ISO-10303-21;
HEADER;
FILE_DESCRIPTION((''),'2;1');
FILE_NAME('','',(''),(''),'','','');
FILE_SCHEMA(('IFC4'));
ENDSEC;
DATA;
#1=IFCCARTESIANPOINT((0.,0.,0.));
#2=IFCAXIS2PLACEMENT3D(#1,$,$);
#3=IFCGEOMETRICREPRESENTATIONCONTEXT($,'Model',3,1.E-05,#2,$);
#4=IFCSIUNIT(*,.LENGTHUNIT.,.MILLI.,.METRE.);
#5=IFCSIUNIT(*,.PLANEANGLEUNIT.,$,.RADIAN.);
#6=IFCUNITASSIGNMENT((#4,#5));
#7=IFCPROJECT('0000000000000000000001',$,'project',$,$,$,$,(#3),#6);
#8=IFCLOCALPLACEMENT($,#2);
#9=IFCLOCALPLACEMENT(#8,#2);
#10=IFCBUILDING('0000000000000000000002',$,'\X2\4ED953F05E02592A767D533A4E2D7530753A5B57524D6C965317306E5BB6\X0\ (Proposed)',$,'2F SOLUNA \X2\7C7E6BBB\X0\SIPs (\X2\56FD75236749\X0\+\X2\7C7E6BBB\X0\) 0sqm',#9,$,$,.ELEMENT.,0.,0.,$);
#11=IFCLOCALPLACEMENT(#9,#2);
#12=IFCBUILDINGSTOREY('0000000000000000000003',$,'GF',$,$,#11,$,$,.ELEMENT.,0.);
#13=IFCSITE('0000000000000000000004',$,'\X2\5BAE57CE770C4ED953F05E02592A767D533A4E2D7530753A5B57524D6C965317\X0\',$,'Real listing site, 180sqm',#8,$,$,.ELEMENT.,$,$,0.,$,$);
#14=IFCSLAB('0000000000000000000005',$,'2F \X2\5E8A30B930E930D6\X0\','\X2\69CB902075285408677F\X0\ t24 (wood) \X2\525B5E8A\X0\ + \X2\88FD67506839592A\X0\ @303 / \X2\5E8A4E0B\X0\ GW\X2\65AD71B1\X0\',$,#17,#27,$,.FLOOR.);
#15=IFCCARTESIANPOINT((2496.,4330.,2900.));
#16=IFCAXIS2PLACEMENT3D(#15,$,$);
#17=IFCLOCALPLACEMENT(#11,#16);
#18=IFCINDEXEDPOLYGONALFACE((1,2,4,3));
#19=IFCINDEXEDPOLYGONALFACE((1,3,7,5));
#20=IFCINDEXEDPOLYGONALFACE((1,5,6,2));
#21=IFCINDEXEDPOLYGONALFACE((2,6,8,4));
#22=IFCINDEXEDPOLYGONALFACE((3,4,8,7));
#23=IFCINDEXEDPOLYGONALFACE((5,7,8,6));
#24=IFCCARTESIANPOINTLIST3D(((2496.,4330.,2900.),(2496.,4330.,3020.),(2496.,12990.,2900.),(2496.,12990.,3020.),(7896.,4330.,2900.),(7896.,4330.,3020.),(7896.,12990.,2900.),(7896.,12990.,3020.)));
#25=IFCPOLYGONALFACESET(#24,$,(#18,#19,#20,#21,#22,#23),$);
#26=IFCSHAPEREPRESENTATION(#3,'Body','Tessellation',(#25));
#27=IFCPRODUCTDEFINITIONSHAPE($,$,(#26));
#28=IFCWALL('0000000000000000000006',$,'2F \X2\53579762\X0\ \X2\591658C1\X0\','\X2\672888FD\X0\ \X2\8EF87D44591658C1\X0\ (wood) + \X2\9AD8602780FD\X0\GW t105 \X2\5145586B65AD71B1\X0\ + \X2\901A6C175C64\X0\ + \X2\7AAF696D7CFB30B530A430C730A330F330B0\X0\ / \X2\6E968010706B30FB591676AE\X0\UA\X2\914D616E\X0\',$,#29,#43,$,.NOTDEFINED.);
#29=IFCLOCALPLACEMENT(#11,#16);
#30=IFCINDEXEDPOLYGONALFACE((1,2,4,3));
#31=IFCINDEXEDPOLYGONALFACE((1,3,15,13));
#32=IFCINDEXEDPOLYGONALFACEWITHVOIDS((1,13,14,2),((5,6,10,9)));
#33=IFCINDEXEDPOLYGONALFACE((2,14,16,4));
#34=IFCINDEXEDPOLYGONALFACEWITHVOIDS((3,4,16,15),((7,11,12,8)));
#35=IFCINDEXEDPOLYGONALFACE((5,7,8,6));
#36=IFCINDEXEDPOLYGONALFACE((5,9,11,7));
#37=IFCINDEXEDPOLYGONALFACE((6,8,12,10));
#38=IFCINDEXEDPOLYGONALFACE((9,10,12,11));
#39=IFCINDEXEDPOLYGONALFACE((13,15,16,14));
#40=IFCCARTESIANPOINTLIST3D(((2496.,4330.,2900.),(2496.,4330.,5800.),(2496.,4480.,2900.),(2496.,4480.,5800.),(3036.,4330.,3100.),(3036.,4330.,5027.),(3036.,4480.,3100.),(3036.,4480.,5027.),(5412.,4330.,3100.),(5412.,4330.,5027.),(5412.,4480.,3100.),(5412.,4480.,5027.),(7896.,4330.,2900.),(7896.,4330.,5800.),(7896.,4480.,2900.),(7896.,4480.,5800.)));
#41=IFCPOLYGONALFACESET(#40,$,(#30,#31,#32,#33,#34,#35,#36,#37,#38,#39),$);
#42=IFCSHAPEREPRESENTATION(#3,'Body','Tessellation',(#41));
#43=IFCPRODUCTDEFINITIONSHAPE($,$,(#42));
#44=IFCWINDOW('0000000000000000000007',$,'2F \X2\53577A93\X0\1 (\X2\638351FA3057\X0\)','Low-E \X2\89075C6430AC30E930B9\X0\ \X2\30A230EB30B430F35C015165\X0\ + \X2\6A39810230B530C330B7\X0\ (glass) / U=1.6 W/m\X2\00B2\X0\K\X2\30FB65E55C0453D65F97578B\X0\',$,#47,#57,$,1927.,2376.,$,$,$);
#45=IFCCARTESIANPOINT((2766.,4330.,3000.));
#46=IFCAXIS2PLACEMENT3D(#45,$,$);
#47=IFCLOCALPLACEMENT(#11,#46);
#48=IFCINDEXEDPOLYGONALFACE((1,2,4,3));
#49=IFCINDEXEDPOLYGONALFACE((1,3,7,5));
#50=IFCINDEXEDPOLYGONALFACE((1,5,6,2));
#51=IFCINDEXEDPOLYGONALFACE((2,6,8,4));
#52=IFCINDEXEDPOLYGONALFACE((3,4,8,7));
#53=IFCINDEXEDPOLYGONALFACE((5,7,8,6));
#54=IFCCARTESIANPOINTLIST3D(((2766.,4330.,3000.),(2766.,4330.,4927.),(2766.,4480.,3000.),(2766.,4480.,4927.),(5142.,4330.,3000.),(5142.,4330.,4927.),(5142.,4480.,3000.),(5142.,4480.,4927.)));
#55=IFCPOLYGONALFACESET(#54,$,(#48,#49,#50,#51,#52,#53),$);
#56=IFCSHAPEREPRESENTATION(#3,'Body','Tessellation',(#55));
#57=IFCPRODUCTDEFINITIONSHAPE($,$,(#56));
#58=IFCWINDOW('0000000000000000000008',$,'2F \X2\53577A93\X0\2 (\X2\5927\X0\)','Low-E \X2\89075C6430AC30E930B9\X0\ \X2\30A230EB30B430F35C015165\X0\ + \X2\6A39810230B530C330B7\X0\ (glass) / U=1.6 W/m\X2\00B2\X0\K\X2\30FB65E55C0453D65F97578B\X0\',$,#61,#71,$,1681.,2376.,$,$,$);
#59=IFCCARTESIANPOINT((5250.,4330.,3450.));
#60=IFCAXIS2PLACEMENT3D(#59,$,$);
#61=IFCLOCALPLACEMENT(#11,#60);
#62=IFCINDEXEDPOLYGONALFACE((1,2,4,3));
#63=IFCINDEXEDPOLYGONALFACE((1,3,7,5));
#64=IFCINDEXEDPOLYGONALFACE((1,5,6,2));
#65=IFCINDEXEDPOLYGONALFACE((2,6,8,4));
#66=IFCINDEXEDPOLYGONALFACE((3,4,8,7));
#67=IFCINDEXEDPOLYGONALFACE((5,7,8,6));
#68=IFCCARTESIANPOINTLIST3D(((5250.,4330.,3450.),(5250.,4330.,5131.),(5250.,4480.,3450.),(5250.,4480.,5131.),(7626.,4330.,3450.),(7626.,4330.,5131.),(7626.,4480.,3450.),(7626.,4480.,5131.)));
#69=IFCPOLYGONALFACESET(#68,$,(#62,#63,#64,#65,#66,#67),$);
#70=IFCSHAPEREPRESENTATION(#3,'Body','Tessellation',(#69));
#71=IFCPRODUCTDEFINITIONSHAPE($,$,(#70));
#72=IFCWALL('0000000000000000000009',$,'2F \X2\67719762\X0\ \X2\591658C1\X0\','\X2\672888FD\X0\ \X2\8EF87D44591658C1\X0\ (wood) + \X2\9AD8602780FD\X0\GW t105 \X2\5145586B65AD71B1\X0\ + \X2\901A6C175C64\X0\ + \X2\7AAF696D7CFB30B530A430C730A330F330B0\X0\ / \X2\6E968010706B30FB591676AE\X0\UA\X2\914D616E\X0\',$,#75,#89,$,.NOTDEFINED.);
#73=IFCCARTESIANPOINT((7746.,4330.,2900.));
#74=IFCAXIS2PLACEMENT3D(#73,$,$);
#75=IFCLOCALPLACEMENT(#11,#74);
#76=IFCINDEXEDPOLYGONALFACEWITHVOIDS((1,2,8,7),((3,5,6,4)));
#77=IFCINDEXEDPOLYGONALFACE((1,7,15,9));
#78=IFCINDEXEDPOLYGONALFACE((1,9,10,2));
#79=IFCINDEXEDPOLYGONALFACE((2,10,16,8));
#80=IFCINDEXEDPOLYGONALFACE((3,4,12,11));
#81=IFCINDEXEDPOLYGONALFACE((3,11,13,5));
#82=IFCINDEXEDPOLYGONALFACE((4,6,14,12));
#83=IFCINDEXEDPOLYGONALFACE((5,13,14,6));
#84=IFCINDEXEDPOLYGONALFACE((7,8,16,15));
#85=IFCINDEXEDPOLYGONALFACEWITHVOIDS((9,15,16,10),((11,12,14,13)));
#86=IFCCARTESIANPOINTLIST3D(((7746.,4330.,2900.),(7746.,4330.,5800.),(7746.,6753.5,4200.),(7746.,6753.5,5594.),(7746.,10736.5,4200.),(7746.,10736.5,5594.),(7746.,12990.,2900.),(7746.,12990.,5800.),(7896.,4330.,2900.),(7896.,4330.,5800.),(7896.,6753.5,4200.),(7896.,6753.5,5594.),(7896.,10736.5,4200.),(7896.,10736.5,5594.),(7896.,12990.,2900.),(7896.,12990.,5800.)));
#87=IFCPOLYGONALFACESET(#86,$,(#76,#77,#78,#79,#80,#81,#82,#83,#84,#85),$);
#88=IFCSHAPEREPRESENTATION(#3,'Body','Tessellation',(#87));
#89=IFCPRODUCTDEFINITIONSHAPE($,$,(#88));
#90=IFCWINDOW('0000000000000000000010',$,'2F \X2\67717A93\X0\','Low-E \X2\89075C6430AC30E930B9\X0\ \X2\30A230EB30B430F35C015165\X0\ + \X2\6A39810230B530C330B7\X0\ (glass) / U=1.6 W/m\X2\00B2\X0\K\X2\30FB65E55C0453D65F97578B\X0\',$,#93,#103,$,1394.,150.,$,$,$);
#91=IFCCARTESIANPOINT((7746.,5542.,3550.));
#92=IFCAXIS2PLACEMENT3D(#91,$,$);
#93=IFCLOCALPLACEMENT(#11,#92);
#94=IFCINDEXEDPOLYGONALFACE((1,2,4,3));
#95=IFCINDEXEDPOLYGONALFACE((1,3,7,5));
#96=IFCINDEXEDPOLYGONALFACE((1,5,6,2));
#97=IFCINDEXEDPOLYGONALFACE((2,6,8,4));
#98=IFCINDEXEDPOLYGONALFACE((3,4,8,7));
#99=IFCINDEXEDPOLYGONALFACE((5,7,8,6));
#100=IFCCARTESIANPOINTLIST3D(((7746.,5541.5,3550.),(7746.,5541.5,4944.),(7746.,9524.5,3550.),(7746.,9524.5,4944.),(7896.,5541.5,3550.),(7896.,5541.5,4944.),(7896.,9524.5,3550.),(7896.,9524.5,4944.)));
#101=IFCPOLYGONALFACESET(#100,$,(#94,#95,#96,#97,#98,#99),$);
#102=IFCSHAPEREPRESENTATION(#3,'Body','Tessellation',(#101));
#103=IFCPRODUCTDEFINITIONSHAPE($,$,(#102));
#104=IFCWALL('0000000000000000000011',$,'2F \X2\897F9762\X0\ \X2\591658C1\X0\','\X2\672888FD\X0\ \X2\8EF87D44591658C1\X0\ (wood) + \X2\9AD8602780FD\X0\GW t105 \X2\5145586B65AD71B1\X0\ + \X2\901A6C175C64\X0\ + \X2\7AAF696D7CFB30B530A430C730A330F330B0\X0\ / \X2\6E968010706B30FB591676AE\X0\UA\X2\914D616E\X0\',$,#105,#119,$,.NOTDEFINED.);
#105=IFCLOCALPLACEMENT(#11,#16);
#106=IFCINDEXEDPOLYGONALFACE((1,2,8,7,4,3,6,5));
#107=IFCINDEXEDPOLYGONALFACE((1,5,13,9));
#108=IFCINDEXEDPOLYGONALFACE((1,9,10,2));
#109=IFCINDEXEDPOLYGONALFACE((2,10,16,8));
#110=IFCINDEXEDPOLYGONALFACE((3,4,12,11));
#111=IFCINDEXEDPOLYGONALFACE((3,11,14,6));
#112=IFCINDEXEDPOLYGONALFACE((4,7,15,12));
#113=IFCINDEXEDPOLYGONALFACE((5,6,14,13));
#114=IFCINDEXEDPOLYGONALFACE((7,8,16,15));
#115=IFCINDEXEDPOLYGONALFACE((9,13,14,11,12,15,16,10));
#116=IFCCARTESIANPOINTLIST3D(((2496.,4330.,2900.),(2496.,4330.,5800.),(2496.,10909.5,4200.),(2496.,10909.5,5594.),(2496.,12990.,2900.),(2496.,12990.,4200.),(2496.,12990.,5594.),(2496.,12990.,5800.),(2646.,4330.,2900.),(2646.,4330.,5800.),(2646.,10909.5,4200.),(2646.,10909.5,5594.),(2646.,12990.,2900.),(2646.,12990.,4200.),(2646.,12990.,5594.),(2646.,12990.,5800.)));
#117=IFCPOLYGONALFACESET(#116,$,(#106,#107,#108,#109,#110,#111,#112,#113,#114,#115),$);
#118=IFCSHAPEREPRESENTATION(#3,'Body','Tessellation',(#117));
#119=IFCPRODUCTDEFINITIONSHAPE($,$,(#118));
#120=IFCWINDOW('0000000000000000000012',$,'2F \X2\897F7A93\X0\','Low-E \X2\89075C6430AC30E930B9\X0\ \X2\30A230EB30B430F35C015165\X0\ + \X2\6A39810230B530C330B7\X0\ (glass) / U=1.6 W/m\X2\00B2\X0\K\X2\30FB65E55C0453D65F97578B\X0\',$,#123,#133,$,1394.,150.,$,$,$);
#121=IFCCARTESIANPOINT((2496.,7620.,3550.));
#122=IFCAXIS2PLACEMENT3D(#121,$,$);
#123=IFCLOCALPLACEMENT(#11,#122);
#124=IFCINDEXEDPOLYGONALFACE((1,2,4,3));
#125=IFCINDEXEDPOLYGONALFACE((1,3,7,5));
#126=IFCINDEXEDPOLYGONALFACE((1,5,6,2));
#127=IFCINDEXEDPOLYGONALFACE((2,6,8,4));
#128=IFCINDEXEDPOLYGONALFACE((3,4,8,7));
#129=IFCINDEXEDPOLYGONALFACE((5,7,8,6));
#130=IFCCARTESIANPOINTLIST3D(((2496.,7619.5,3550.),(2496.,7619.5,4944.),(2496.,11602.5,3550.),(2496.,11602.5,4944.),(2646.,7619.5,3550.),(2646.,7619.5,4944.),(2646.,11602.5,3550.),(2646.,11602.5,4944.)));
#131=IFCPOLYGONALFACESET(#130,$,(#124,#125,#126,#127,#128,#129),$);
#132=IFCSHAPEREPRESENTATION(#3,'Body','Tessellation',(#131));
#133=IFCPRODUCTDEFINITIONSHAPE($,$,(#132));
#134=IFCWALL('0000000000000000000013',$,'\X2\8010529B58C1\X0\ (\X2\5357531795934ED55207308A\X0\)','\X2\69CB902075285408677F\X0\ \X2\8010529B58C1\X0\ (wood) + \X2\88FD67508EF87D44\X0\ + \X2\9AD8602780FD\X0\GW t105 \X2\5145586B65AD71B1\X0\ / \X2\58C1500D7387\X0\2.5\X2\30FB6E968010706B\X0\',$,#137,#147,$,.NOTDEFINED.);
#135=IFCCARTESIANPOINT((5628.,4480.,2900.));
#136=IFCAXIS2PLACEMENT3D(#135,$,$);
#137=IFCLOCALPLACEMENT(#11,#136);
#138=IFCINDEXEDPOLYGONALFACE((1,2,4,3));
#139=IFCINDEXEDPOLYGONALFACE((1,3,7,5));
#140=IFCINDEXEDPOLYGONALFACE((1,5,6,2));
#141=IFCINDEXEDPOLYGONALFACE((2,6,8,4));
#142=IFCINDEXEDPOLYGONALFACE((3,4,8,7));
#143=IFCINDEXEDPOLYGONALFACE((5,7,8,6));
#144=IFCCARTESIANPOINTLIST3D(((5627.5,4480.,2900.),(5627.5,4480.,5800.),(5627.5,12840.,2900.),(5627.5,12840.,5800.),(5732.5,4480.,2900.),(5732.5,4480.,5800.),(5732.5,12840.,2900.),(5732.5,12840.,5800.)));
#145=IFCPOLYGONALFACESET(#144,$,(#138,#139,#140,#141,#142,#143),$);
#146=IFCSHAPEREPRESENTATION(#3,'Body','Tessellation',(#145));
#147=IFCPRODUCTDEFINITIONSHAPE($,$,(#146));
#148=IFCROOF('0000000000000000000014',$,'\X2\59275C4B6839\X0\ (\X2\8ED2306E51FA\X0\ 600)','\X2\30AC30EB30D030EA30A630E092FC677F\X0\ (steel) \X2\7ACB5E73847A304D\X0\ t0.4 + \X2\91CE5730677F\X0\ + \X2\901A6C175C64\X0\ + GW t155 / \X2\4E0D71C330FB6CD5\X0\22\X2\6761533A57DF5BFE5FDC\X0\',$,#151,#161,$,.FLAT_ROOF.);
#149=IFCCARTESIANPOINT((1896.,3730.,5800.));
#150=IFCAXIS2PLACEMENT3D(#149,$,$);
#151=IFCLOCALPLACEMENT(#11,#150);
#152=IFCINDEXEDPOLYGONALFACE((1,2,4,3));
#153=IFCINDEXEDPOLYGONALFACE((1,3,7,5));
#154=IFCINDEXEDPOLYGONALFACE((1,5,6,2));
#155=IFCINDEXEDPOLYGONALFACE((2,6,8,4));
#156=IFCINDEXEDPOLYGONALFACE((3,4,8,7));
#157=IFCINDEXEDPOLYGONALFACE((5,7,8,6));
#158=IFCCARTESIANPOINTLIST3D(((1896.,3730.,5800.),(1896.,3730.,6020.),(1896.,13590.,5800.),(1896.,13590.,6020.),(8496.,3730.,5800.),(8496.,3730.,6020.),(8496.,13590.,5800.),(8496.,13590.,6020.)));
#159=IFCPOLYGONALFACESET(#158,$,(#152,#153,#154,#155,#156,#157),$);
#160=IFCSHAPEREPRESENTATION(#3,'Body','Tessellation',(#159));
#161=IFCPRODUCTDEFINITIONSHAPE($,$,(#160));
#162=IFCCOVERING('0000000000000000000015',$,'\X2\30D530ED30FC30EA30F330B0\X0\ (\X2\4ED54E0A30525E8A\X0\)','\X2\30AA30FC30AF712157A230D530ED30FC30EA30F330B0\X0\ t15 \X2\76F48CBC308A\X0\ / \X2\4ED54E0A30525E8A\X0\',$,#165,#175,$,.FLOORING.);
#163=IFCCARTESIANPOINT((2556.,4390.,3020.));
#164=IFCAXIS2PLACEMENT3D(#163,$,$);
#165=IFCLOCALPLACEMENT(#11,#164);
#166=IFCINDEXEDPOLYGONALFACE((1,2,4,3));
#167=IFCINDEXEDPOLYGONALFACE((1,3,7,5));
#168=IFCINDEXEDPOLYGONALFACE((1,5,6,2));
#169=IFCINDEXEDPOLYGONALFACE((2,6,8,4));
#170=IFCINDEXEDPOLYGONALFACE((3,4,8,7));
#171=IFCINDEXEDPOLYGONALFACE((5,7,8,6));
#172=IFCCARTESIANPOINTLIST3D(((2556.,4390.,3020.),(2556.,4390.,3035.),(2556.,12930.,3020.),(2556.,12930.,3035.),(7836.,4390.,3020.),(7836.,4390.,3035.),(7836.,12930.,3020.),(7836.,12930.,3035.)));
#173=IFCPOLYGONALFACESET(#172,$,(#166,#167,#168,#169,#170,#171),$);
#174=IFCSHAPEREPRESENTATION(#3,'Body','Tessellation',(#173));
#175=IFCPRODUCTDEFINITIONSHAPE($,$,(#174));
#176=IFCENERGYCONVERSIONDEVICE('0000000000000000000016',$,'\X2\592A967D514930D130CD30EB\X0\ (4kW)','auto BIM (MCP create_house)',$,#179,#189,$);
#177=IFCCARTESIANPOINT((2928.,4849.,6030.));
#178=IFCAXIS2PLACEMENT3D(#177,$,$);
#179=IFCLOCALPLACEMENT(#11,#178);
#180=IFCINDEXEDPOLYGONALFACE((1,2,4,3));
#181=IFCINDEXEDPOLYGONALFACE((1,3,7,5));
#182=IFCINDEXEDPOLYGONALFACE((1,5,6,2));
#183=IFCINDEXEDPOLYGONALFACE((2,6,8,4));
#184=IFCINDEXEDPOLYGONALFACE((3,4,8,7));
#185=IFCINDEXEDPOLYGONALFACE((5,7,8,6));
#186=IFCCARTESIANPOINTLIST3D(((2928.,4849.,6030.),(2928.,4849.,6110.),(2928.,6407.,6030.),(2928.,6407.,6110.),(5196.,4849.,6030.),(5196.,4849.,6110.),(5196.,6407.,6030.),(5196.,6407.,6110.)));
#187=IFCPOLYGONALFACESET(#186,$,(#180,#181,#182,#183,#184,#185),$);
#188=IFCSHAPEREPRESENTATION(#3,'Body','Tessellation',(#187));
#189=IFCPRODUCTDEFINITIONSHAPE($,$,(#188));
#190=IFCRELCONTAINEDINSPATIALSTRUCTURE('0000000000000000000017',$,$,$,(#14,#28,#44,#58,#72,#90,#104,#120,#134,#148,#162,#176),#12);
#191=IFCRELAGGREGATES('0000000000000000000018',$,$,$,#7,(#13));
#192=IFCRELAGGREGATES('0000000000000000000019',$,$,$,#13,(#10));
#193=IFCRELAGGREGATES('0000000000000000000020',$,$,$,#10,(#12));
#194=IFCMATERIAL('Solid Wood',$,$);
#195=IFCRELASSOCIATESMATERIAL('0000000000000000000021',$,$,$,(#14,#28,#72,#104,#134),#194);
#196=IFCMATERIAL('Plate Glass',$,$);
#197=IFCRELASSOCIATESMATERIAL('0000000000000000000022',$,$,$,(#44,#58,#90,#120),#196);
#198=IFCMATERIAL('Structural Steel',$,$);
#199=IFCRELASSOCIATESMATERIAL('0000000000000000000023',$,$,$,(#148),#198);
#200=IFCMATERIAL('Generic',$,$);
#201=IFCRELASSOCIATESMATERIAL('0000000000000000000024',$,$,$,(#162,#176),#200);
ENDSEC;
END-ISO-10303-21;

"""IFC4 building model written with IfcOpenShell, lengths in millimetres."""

from ifc_helpers import new_model, si_unit, frame, frame_2d, origin, place, context, project, spatial, rectangle, extrude, material, element, fill, save


model = new_model("IFC4")

# Units and contexts
model_context = context("Model", 3, precision=1e-05, world=origin())
ifc_project = project(units=[si_unit("LENGTHUNIT", "METRE", prefix="MILLI"), si_unit("PLANEANGLEUNIT", "RADIAN")], contexts=[model_context])

# Site, building, storey
site_placement = place(None, origin())
site = spatial("IfcSite", under=ifc_project, at=site_placement, Name="宮城県仙台市太白区中田町字前沖北", ObjectType="Real listing site, 180sqm", CompositionType="ELEMENT", RefElevation=0.0)
building_placement = place(site_placement, origin())
building = spatial("IfcBuilding", under=site, at=building_placement, Name="仙台市太白区中田町字前沖北の家 (Proposed)", ObjectType="2F SOLUNA 籾殻SIPs (国産杉+籾殻) 0sqm", CompositionType="ELEMENT", ElevationOfRefHeight=0.0, ElevationOfTerrain=0.0)
storey_placement = place(building_placement, origin())
storey = spatial("IfcBuildingStorey", under=building, at=storey_placement, Name="GF", CompositionType="ELEMENT", Elevation=0.0)

# Slab
ifc_material_1 = material(Name="Solid Wood")
slab_placement = place(storey_placement, frame((2496.0, 4330.0, 2900.0)))
element("IfcSlab", 1, at=slab_placement, inside=storey, material=ifc_material_1, Name="2F 床スラブ", Description="構造用合板 t24 (wood) 剛床 + 製材根太 @303 / 床下 GW断熱", PredefinedType="FLOOR", context=model_context, shape_type="SweptSolid", body=[
    extrude(rectangle(XDim=5400.0, YDim=8660.0, at=frame_2d((2700.0, 4330.0))), frame((2496.0, 4330.0, 2900.0)), (0.0, 0.0, 1.0), 120.0),
])

# Wall, openings, windows
wall_1_placement = place(storey_placement, frame((2496.0, 4330.0, 2900.0)))
wall_1 = element("IfcWall", 2, at=wall_1_placement, inside=storey, material=ifc_material_1, Name="2F 南面 外壁", Description="木製 軸組外壁 (wood) + 高性能GW t105 充填断熱 + 通気層 + 窯業系サイディング / 準耐火・外皮UA配慮", PredefinedType="NOTDEFINED", context=model_context, shape_type="SweptSolid", body=[
    extrude(rectangle(XDim=5400.0, YDim=150.0, at=frame_2d((2700.0, 75.0))), frame((2496.0, 4330.0, 2900.0)), (0.0, 0.0, 1.0), 2900.0),
])
opening_1_placement = place(storey_placement, frame((2766.0, 4330.0, 3000.0)))
opening_1 = element("IfcOpeningElement", 3, at=opening_1_placement, cuts=wall_1, PredefinedType="NOTDEFINED", context=model_context, shape_type="SweptSolid", body=[
    extrude(rectangle(XDim=2376.0, YDim=150.0, at=frame_2d((1188.0, 75.0))), frame((2766.0, 4330.0, 3000.0)), (0.0, 0.0, 1.0), 1927.0),
])
opening_2_placement = place(storey_placement, frame((5250.0, 4330.0, 3450.0)))
opening_2 = element("IfcOpeningElement", 4, at=opening_2_placement, cuts=wall_1, PredefinedType="NOTDEFINED", context=model_context, shape_type="SweptSolid", body=[
    extrude(rectangle(XDim=2376.0, YDim=150.0, at=frame_2d((1188.0, 75.0))), frame((5250.0, 4330.0, 3450.0)), (0.0, 0.0, 1.0), 1681.0),
])
ifc_material_2 = material(Name="Plate Glass")
window_1_placement = place(storey_placement, frame((2766.0, 4330.0, 3000.0)))
window_1 = element("IfcWindow", 5, at=window_1_placement, inside=storey, material=ifc_material_2, Name="2F 南窓1 (掃出し)", Description="Low-E 複層ガラス アルゴン封入 + 樹脂サッシ (glass) / U=1.6 W/m²K・日射取得型", OverallHeight=1927.0, OverallWidth=2376.0, context=model_context, shape_type="SweptSolid", body=[
    extrude(rectangle(XDim=2376.0, YDim=150.0, at=frame_2d((1188.0, 75.0))), frame((2766.0, 4330.0, 3000.0)), (0.0, 0.0, 1.0), 1927.0),
])
fill(opening_1, window_1)
window_2_placement = place(storey_placement, frame((5250.0, 4330.0, 3450.0)))
window_2 = element("IfcWindow", 6, at=window_2_placement, inside=storey, material=ifc_material_2, Name="2F 南窓2 (大)", Description="Low-E 複層ガラス アルゴン封入 + 樹脂サッシ (glass) / U=1.6 W/m²K・日射取得型", OverallHeight=1681.0, OverallWidth=2376.0, context=model_context, shape_type="SweptSolid", body=[
    extrude(rectangle(XDim=2376.0, YDim=150.0, at=frame_2d((1188.0, 75.0))), frame((5250.0, 4330.0, 3450.0)), (0.0, 0.0, 1.0), 1681.0),
])
fill(opening_2, window_2)

# Walls, openings, windows
wall_2_placement = place(storey_placement, frame((7746.0, 4330.0, 2900.0)))
wall_2 = element("IfcWall", 7, at=wall_2_placement, inside=storey, material=ifc_material_1, Name="2F 東面 外壁", Description="木製 軸組外壁 (wood) + 高性能GW t105 充填断熱 + 通気層 + 窯業系サイディング / 準耐火・外皮UA配慮", PredefinedType="NOTDEFINED", context=model_context, shape_type="SweptSolid", body=[
    extrude(rectangle(XDim=150.0, YDim=8660.0, at=frame_2d((75.0, 4330.0))), frame((7746.0, 4330.0, 2900.0)), (0.0, 0.0, 1.0), 2900.0),
])
opening_3_placement = place(storey_placement, frame((7746.0, 5542.0, 3550.0)))
opening_3 = element("IfcOpeningElement", 8, at=opening_3_placement, cuts=wall_2, PredefinedType="NOTDEFINED", context=model_context, shape_type="SweptSolid", body=[
    extrude(rectangle(XDim=150.0, YDim=3983.0, at=frame_2d((75.0, 1991.0))), frame((7746.0, 5542.0, 3550.0)), (0.0, 0.0, 1.0), 1394.0),
])
window_3_placement = place(storey_placement, frame((7746.0, 5542.0, 3550.0)))
window_3 = element("IfcWindow", 9, at=window_3_placement, inside=storey, material=ifc_material_2, Name="2F 東窓", Description="Low-E 複層ガラス アルゴン封入 + 樹脂サッシ (glass) / U=1.6 W/m²K・日射取得型", OverallHeight=1394.0, OverallWidth=150.0, context=model_context, shape_type="SweptSolid", body=[
    extrude(rectangle(XDim=150.0, YDim=3983.0, at=frame_2d((75.0, 1991.0))), frame((7746.0, 5542.0, 3550.0)), (0.0, 0.0, 1.0), 1394.0),
])
fill(opening_3, window_3)
wall_3_placement = place(storey_placement, frame((2496.0, 4330.0, 2900.0)))
wall_3 = element("IfcWall", 10, at=wall_3_placement, inside=storey, material=ifc_material_1, Name="2F 西面 外壁", Description="木製 軸組外壁 (wood) + 高性能GW t105 充填断熱 + 通気層 + 窯業系サイディング / 準耐火・外皮UA配慮", PredefinedType="NOTDEFINED", context=model_context, shape_type="SweptSolid", body=[
    extrude(rectangle(XDim=150.0, YDim=8660.0, at=frame_2d((75.0, 4330.0))), frame((2496.0, 4330.0, 2900.0)), (0.0, 0.0, 1.0), 2900.0),
])
opening_4_placement = place(storey_placement, frame((2496.0, 7620.0, 3550.0)))
opening_4 = element("IfcOpeningElement", 11, at=opening_4_placement, cuts=wall_3, PredefinedType="NOTDEFINED", context=model_context, shape_type="SweptSolid", body=[
    extrude(rectangle(XDim=150.0, YDim=3983.0, at=frame_2d((75.0, 1991.0))), frame((2496.0, 7620.0, 3550.0)), (0.0, 0.0, 1.0), 1394.0),
])
window_4_placement = place(storey_placement, frame((2496.0, 7620.0, 3550.0)))
window_4 = element("IfcWindow", 12, at=window_4_placement, inside=storey, material=ifc_material_2, Name="2F 西窓", Description="Low-E 複層ガラス アルゴン封入 + 樹脂サッシ (glass) / U=1.6 W/m²K・日射取得型", OverallHeight=1394.0, OverallWidth=150.0, context=model_context, shape_type="SweptSolid", body=[
    extrude(rectangle(XDim=150.0, YDim=3983.0, at=frame_2d((75.0, 1991.0))), frame((2496.0, 7620.0, 3550.0)), (0.0, 0.0, 1.0), 1394.0),
])
fill(opening_4, window_4)

# Wall
wall_4_placement = place(storey_placement, frame((5628.0, 4480.0, 2900.0)))
element("IfcWall", 13, at=wall_4_placement, inside=storey, material=ifc_material_1, Name="耐力壁 (南北間仕切り)", Description="構造用合板 耐力壁 (wood) + 製材軸組 + 高性能GW t105 充填断熱 / 壁倍率2.5・準耐火", PredefinedType="NOTDEFINED", context=model_context, shape_type="SweptSolid", body=[
    extrude(rectangle(XDim=105.0, YDim=8360.0, at=frame_2d((52.0, 4180.0))), frame((5628.0, 4480.0, 2900.0)), (0.0, 0.0, 1.0), 2900.0),
])

# Roof
ifc_material_3 = material(Name="Structural Steel")
roof_placement = place(storey_placement, frame((1896.0, 3730.0, 5800.0)))
element("IfcRoof", 14, at=roof_placement, inside=storey, material=ifc_material_3, Name="大屋根 (軒の出 600)", Description="ガルバリウム鋼板 (steel) 立平葺き t0.4 + 野地板 + 通気層 + GW t155 / 不燃・法22条区域対応", PredefinedType="FLAT_ROOF", context=model_context, shape_type="SweptSolid", body=[
    extrude(rectangle(XDim=6600.0, YDim=9860.0, at=frame_2d((3300.0, 4930.0))), frame((1896.0, 3730.0, 5800.0)), (0.0, 0.0, 1.0), 220.0),
])

# Covering
ifc_material_4 = material(Name="Generic")
covering_placement = place(storey_placement, frame((2556.0, 4390.0, 3020.0)))
element("IfcCovering", 15, at=covering_placement, inside=storey, material=ifc_material_4, Name="フローリング (仕上げ床)", Description="オーク無垢フローリング t15 直貼り / 仕上げ床", PredefinedType="FLOORING", context=model_context, shape_type="SweptSolid", body=[
    extrude(rectangle(XDim=5280.0, YDim=8540.0, at=frame_2d((2640.0, 4270.0))), frame((2556.0, 4390.0, 3020.0)), (0.0, 0.0, 1.0), 15.0),
])

# Energy conversion device
energy_conversion_device_placement = place(storey_placement, frame((2928.0, 4849.0, 6030.0)))
element("IfcEnergyConversionDevice", 16, at=energy_conversion_device_placement, inside=storey, material=ifc_material_4, Name="太陽光パネル (4kW)", Description="auto BIM (MCP create_house)", context=model_context, shape_type="SweptSolid", body=[
    extrude(rectangle(XDim=2268.0, YDim=1558.0, at=frame_2d((1134.0, 779.0))), frame((2928.0, 4849.0, 6030.0)), (0.0, 0.0, 1.0), 80.0),
])

save(model, "model.ifc")
